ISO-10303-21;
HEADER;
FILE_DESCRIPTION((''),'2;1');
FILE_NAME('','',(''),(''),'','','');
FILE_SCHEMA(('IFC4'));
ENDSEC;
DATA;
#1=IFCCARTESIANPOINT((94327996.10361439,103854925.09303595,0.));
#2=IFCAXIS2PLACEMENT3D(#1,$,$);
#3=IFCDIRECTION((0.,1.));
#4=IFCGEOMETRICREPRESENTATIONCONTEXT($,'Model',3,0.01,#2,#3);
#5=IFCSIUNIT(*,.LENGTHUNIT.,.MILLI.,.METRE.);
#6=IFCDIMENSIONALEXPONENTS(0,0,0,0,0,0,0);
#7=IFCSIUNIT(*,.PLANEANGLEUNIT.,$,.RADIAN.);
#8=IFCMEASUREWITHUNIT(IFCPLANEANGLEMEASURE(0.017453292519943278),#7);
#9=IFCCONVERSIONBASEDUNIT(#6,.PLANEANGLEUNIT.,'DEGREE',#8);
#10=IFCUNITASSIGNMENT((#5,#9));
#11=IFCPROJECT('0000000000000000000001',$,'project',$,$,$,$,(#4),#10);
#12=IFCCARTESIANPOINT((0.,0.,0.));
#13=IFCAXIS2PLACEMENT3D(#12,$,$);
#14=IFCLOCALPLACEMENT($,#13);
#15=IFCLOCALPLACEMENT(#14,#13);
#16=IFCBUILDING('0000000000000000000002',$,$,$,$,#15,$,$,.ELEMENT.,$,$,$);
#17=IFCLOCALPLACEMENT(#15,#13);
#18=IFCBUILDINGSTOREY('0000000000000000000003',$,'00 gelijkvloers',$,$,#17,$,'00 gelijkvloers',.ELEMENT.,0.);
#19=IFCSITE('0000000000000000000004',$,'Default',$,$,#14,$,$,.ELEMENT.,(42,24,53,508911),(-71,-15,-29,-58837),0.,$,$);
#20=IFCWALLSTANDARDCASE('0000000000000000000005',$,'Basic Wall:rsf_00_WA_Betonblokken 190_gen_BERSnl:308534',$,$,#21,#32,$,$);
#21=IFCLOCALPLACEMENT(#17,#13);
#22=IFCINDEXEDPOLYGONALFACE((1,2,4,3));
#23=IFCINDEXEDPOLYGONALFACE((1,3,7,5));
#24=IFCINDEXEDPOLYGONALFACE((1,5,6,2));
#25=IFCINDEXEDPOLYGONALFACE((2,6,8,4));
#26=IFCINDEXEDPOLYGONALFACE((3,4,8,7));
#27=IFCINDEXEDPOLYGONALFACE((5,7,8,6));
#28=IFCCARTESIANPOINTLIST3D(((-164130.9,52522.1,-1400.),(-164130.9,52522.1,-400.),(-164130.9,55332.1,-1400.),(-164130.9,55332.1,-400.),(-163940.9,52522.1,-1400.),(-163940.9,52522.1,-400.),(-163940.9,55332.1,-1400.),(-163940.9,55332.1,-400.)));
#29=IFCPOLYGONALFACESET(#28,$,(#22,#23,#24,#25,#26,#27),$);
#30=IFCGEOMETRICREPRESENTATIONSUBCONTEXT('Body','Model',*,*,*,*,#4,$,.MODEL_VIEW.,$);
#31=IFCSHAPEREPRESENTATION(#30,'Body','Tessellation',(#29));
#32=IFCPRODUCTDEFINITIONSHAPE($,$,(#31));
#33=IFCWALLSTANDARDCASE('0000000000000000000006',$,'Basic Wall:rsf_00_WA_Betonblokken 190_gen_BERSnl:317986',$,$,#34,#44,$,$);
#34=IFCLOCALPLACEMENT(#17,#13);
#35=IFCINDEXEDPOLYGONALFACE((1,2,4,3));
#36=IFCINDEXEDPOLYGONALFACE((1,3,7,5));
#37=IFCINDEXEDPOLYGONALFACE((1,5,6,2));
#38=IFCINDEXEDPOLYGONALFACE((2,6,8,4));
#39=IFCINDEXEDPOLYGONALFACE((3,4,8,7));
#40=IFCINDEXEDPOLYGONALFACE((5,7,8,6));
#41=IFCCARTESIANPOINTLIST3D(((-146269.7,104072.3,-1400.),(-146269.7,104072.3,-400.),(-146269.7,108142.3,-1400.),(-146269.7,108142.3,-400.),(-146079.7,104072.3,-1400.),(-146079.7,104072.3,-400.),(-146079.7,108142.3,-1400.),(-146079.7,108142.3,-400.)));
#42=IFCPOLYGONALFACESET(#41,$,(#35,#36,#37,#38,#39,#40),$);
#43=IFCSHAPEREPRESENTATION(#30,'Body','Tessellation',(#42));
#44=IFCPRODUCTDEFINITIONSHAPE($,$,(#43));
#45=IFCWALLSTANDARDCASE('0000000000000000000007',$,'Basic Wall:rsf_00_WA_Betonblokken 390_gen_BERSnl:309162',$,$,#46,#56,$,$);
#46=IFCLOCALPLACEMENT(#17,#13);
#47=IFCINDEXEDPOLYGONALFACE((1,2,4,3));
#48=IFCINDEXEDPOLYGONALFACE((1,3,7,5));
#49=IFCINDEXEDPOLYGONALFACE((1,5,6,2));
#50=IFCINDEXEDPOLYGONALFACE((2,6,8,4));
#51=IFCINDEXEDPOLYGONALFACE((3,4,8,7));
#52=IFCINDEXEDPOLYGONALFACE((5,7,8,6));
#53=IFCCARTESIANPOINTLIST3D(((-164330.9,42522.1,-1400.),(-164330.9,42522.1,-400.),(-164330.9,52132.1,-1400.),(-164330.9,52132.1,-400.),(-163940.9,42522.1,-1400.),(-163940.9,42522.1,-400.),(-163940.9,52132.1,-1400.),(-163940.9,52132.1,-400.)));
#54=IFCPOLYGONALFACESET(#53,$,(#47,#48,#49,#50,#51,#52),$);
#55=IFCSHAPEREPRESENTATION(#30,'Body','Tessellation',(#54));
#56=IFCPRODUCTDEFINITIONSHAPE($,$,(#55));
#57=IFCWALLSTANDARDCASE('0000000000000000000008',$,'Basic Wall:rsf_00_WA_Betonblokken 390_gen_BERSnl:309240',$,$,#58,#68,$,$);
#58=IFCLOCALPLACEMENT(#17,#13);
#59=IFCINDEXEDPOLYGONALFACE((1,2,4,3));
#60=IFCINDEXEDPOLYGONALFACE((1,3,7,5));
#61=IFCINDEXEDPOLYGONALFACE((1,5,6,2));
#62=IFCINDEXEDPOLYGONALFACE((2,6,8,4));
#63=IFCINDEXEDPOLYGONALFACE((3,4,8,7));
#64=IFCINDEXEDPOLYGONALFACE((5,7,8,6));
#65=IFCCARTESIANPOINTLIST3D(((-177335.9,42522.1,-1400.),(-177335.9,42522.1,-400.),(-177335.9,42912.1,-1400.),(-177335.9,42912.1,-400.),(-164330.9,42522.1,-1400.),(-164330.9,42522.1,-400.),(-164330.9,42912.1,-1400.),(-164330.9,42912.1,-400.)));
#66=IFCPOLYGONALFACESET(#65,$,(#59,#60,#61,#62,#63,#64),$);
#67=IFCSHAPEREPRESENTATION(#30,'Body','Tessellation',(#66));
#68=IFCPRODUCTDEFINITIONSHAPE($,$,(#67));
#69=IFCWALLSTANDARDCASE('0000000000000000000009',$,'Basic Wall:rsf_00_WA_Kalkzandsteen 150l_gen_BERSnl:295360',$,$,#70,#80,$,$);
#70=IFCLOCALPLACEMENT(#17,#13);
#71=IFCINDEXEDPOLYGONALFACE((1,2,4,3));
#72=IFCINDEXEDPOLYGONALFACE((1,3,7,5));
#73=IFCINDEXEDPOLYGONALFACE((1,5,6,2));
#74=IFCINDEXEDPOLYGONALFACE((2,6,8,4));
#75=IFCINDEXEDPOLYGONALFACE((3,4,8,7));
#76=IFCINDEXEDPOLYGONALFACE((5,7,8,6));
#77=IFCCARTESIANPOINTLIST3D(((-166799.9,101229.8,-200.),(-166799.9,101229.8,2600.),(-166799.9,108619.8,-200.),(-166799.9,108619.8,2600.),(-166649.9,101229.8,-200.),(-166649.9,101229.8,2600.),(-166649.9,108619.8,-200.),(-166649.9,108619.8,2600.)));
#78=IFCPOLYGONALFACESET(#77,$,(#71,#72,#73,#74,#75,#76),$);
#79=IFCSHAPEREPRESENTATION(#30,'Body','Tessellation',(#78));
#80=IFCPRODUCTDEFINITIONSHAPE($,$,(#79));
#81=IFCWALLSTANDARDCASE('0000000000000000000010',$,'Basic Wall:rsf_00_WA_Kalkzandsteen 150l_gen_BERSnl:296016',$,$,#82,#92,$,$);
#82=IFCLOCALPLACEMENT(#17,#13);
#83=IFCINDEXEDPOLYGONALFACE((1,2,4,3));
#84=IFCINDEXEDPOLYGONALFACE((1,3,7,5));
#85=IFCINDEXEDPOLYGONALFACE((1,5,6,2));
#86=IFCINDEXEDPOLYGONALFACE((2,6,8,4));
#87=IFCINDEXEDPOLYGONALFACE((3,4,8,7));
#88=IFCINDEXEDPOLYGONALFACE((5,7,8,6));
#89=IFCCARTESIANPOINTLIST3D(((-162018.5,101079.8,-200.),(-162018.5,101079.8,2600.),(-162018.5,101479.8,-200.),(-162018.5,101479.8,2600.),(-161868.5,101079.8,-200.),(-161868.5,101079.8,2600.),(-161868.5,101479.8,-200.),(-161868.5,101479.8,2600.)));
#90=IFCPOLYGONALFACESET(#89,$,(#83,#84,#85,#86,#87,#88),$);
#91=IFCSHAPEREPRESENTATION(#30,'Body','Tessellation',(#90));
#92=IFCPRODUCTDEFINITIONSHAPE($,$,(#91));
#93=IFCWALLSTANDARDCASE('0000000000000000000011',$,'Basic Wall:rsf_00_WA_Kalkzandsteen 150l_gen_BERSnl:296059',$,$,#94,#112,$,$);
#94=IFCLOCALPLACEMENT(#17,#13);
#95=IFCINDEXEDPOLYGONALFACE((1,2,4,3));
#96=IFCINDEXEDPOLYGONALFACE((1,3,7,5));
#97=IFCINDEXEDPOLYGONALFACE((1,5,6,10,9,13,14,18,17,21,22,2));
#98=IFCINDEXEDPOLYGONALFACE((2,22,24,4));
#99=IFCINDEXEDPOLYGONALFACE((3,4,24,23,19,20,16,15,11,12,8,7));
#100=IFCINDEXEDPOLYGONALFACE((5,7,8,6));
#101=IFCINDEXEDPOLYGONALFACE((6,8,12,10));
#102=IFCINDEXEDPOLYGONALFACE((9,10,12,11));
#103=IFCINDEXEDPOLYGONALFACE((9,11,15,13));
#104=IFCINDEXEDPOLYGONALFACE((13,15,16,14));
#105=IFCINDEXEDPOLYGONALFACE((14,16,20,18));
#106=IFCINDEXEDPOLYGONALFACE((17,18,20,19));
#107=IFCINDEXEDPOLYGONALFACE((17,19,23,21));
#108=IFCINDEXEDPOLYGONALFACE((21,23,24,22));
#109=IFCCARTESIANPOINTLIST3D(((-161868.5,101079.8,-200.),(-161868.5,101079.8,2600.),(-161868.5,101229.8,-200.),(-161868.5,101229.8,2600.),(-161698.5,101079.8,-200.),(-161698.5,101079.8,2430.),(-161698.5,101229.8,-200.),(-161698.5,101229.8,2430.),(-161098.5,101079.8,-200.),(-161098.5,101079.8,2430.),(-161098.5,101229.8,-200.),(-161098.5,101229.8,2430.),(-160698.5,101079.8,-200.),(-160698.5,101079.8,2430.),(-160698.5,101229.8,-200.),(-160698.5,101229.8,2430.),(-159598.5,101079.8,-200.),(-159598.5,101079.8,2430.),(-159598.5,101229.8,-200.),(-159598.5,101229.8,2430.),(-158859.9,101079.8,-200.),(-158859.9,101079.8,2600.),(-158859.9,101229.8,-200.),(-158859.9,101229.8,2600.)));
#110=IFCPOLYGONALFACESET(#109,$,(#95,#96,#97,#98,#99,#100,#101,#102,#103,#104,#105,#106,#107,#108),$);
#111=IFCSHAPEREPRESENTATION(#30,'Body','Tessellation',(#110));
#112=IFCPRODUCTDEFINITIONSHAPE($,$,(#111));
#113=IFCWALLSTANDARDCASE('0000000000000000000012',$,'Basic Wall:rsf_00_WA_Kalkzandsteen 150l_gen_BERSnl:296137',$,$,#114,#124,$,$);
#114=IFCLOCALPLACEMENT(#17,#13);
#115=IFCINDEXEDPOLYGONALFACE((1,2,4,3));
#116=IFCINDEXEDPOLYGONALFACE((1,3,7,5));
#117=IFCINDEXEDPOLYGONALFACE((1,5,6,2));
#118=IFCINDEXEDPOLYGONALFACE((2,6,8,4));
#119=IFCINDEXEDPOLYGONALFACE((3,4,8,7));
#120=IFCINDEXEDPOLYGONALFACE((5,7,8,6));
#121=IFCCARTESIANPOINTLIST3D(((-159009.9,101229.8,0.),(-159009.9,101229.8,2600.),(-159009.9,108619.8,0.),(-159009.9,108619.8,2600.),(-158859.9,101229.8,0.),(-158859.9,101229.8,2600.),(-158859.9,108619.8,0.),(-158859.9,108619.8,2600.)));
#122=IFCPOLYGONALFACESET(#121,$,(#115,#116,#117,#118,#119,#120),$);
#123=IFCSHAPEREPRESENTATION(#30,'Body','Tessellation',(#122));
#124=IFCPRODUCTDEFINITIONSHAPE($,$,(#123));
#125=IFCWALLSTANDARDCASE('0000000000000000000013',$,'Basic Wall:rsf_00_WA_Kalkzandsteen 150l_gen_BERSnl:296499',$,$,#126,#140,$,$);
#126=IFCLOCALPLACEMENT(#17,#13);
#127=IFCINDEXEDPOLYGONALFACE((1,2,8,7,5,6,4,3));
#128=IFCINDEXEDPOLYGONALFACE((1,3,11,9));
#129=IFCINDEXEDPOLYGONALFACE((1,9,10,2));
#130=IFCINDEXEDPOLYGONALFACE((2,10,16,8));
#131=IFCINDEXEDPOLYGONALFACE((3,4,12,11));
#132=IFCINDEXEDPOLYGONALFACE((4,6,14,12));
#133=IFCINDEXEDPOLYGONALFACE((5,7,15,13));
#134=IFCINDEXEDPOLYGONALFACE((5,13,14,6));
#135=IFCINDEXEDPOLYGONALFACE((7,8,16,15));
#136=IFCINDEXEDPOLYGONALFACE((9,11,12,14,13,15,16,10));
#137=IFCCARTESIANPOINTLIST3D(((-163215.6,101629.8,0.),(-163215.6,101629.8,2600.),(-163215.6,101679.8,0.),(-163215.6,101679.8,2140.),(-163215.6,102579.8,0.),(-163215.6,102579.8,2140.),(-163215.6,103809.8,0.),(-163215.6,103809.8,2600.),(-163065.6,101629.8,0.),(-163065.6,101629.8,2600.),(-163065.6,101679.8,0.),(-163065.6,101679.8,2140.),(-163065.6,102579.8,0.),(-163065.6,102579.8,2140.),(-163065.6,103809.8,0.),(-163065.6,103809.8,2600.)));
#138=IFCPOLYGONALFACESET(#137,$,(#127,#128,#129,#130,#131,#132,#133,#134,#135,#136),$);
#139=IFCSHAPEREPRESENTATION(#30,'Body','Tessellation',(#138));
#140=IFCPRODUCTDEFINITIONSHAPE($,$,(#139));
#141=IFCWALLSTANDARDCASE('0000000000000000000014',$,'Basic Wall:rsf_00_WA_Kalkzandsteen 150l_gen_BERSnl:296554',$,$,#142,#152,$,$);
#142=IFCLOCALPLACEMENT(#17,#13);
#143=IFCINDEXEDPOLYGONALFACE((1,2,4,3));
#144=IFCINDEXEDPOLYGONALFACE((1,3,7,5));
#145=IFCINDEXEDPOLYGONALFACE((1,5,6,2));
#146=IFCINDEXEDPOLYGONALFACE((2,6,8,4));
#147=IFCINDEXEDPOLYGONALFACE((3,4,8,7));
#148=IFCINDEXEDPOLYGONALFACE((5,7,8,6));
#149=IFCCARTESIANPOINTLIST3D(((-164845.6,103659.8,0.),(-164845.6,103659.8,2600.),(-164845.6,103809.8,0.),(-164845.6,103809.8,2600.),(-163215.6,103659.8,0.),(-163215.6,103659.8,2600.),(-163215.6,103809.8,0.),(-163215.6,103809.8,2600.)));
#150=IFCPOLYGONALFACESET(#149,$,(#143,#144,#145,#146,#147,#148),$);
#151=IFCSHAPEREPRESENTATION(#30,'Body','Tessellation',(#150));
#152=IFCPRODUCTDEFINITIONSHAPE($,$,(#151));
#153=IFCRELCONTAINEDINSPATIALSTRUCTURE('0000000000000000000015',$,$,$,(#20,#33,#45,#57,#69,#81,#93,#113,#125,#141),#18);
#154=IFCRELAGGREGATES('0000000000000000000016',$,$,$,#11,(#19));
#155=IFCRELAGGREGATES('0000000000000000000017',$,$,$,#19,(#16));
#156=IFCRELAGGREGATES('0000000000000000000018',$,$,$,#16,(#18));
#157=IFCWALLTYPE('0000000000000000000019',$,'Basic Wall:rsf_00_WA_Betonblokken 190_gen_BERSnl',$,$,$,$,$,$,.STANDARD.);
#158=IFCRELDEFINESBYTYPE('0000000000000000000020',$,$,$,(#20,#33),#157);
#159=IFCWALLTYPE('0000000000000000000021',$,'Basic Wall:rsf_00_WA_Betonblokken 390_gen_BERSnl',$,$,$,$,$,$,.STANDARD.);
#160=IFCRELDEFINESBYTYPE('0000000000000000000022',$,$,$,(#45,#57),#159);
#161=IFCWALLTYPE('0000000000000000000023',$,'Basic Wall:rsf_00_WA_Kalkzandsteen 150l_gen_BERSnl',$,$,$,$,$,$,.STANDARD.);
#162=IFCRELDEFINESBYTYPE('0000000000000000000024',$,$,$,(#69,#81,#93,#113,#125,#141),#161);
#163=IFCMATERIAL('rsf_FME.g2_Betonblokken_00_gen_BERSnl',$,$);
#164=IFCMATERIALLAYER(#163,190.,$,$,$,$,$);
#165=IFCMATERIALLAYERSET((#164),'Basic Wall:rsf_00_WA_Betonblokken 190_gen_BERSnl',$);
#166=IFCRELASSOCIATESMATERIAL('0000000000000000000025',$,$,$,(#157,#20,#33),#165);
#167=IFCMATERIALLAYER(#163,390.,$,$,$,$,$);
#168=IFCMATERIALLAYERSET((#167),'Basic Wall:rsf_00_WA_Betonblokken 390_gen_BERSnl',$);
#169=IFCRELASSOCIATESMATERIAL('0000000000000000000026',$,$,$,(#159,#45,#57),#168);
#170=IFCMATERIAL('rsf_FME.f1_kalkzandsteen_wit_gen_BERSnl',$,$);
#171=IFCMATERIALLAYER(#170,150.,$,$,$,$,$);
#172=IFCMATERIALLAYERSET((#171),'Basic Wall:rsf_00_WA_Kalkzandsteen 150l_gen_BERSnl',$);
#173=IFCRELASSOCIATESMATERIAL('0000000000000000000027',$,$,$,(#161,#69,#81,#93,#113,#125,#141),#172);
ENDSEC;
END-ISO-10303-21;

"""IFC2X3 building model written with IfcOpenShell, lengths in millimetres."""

from ifc_helpers import new_model, entity, si_unit, converted_unit, direction, frame, frame_2d, origin, origin_2d_with_axis, place, context, subcontext, project, spatial, polyline, rectangle, extrude, clip, bounded_halfspace, material, layer, layer_set, layer_usage, type_object, element, save


model = new_model("IFC2X3")

# Units and contexts
model_context = context("Model", 3, precision=0.01, world=frame((94327996.10361439, 103854925.09303595, 0.0)), true_north=direction((0.0, 1.0)))
body_context = subcontext(model_context, "Body", "Model", "MODEL_VIEW")
ifc_project = project(units=[si_unit("LENGTHUNIT", "METRE", prefix="MILLI"), converted_unit("PLANEANGLEUNIT", "DEGREE", entity("IfcPlaneAngleMeasure", 0.017453292519943278), si_unit("PLANEANGLEUNIT", "RADIAN"), dimensions=[0, 0, 0, 0, 0, 0, 0])], contexts=[model_context])

# Site, building, storey
site_placement = place(None, origin())
site = spatial("IfcSite", under=ifc_project, at=site_placement, Name="Default", CompositionType="ELEMENT", RefLatitude=(42, 24, 53, 508911), RefLongitude=(-71, -15, -29, -58837), RefElevation=0.0)
building_placement = place(site_placement, origin())
building = spatial("IfcBuilding", under=site, at=building_placement, CompositionType="ELEMENT")
storey_placement = place(building_placement, origin())
storey = spatial("IfcBuildingStorey", under=building, at=storey_placement, Name="00 gelijkvloers", LongName="00 gelijkvloers", CompositionType="ELEMENT", Elevation=0.0)

# Walls
ifc_material_1 = material(Name="rsf_FME.g2_Betonblokken_00_gen_BERSnl")
ifc_layer_1 = layer(ifc_material_1, 190.0)
ifc_layer_set_1 = layer_set([ifc_layer_1], Name="Basic Wall:rsf_00_WA_Betonblokken 190_gen_BERSnl")
ifc_layer_usage_1 = layer_usage(ifc_layer_set_1, "AXIS2", "POSITIVE", -95.0)
wall_type_1 = type_object("IfcWallType", Name="Basic Wall:rsf_00_WA_Betonblokken 190_gen_BERSnl", PredefinedType="STANDARD", material=ifc_layer_set_1)
wall_1_placement = place(storey_placement, frame((-164035.9, 55332.1, -1400.0), z_axis=(0.0, 0.0, 1.0), x_axis=(0.0, -1.0, 0.0)))
element("IfcWallStandardCase", 1, at=wall_1_placement, inside=storey, type_object=wall_type_1, material=ifc_layer_usage_1, Name="Basic Wall:rsf_00_WA_Betonblokken 190_gen_BERSnl:308534", context=body_context, shape_type="SweptSolid", body=[
    extrude(rectangle(XDim=2810.0, YDim=190.0, at=frame_2d((1405.0, 0.0), x_axis=(-1.0, 0.0))), origin(), (0.0, 0.0, 1.0), 1000.0),
])
ifc_layer_usage_2 = layer_usage(ifc_layer_set_1, "AXIS2", "POSITIVE", -95.0)
wall_2_placement = place(storey_placement, frame((-146174.7, 104072.3, -1400.0), z_axis=(0.0, 0.0, 1.0), x_axis=(0.0, 1.0, 0.0)))
element("IfcWallStandardCase", 2, at=wall_2_placement, inside=storey, type_object=wall_type_1, material=ifc_layer_usage_2, Name="Basic Wall:rsf_00_WA_Betonblokken 190_gen_BERSnl:317986", context=body_context, shape_type="SweptSolid", body=[
    extrude(rectangle(XDim=4070.0, YDim=190.0, at=frame_2d((2035.0, 0.0), x_axis=(-1.0, 0.0))), origin(), (0.0, 0.0, 1.0), 1000.0),
])
ifc_layer_2 = layer(ifc_material_1, 390.0)
ifc_layer_set_2 = layer_set([ifc_layer_2], Name="Basic Wall:rsf_00_WA_Betonblokken 390_gen_BERSnl")
ifc_layer_usage_3 = layer_usage(ifc_layer_set_2, "AXIS2", "NEGATIVE", 195.0)
wall_type_2 = type_object("IfcWallType", Name="Basic Wall:rsf_00_WA_Betonblokken 390_gen_BERSnl", PredefinedType="STANDARD", material=ifc_layer_set_2)
wall_3_placement = place(storey_placement, frame((-164135.9, 52132.1, -1400.0), z_axis=(0.0, 0.0, 1.0), x_axis=(0.0, -1.0, 0.0)))
element("IfcWallStandardCase", 3, at=wall_3_placement, inside=storey, type_object=wall_type_2, material=ifc_layer_usage_3, Name="Basic Wall:rsf_00_WA_Betonblokken 390_gen_BERSnl:309162", context=body_context, shape_type="SweptSolid", body=[
    extrude(rectangle(XDim=9610.0, YDim=390.0, at=frame_2d((4805.0, 0.0), x_axis=(-1.0, 0.0))), origin(), (0.0, 0.0, 1.0), 1000.0),
])
ifc_layer_usage_4 = layer_usage(ifc_layer_set_2, "AXIS2", "NEGATIVE", 195.0)
wall_4_placement = place(storey_placement, frame((-164330.9, 42717.1, -1400.0), z_axis=(0.0, 0.0, 1.0), x_axis=(-1.0, 0.0, 0.0)))
element("IfcWallStandardCase", 4, at=wall_4_placement, inside=storey, type_object=wall_type_2, material=ifc_layer_usage_4, Name="Basic Wall:rsf_00_WA_Betonblokken 390_gen_BERSnl:309240", context=body_context, shape_type="SweptSolid", body=[
    extrude(rectangle(XDim=13005.0, YDim=390.0, at=frame_2d((6502.5, 0.0), x_axis=(-1.0, 0.0))), origin(), (0.0, 0.0, 1.0), 1000.0),
])
ifc_material_2 = material(Name="rsf_FME.f1_kalkzandsteen_wit_gen_BERSnl")
ifc_layer_3 = layer(ifc_material_2, 150.0)
ifc_layer_set_3 = layer_set([ifc_layer_3], Name="Basic Wall:rsf_00_WA_Kalkzandsteen 150l_gen_BERSnl")
ifc_layer_usage_5 = layer_usage(ifc_layer_set_3, "AXIS2", "NEGATIVE", 75.0)
wall_type_3 = type_object("IfcWallType", Name="Basic Wall:rsf_00_WA_Kalkzandsteen 150l_gen_BERSnl", PredefinedType="STANDARD", material=ifc_layer_set_3)
wall_5_placement = place(storey_placement, frame((-166724.9, 101229.8, -200.0), z_axis=(0.0, 0.0, 1.0), x_axis=(0.0, 1.0, 0.0)))
element("IfcWallStandardCase", 5, at=wall_5_placement, inside=storey, type_object=wall_type_3, material=ifc_layer_usage_5, Name="Basic Wall:rsf_00_WA_Kalkzandsteen 150l_gen_BERSnl:295360", context=body_context, shape_type="Clipping", body=[
    clip(extrude(rectangle(XDim=7390.0, YDim=150.0, at=frame_2d((3695.0, 0.0), x_axis=(-1.0, 0.0))), origin(), (0.0, 0.0, 1.0), 2800.0), bounded_halfspace(frame((0.0, -75.0, 2800.0), z_axis=(0.0, 0.0, -1.0), x_axis=(1.0, 0.0, 0.0)), True, frame((0.0, -75.0, 2800.0)), polyline([(0.0, 0.0), (250.0, 0.0), (7390.0, 0.0), (7390.0, 150.0), (7240.0, 150.0), (0.0, 150.0), (0.0, 0.0)]))),
])
ifc_layer_usage_6 = layer_usage(ifc_layer_set_3, "AXIS2", "NEGATIVE", 75.0)
wall_6_placement = place(storey_placement, frame((-161943.5, 101479.8, -200.0), z_axis=(0.0, 0.0, 1.0), x_axis=(0.0, -1.0, 0.0)))
element("IfcWallStandardCase", 6, at=wall_6_placement, inside=storey, type_object=wall_type_3, material=ifc_layer_usage_6, Name="Basic Wall:rsf_00_WA_Kalkzandsteen 150l_gen_BERSnl:296016", context=body_context, shape_type="Clipping", body=[
    clip(extrude(rectangle(XDim=400.0, YDim=150.0, at=frame_2d((200.0, 0.0), x_axis=(-1.0, 0.0))), origin(), (0.0, 0.0, 1.0), 2800.0), bounded_halfspace(frame((0.0, -75.0, 2800.0), z_axis=(0.0, 0.0, -1.0), x_axis=(-1.0, 0.0, 0.0)), True, frame((0.0, -75.0, 2800.0)), polyline([(0.0, 0.0), (400.0, 0.0), (400.0, 150.0), (250.0, 150.0), (0.0, 150.0), (0.0, 0.0)]))),
])

# Wall, openings
ifc_layer_usage_7 = layer_usage(ifc_layer_set_3, "AXIS2", "NEGATIVE", 75.0)
wall_7_placement = place(storey_placement, frame((-161868.5, 101154.8, -200.0)))
wall_7 = element("IfcWallStandardCase", 7, at=wall_7_placement, inside=storey, type_object=wall_type_3, material=ifc_layer_usage_7, Name="Basic Wall:rsf_00_WA_Kalkzandsteen 150l_gen_BERSnl:296059", context=body_context, shape_type="Clipping", body=[
    clip(extrude(rectangle(XDim=3008.6, YDim=150.0, at=frame_2d((1504.3, 0.0), x_axis=(-1.0, 0.0))), origin(), (0.0, 0.0, 1.0), 2800.0), bounded_halfspace(frame((0.0, -75.0, 2800.0), z_axis=(0.0, 0.0, -1.0), x_axis=(0.0, 1.0, 0.0)), True, frame((0.0, -75.0, 2800.0)), polyline([(0.0, 0.0), (3008.6, 0.0), (3008.6, 150.0), (2858.6, 150.0), (0.0, 150.0), (0.0, 0.0)]))),
])
opening_1_placement = place(wall_7_placement, frame((161868.5, -101154.8, 200.0)))
element("IfcOpeningElement", 8, at=opening_1_placement, cuts=wall_7, ObjectType="Opening", context=body_context, shape_type="SweptSolid", body=[
    extrude(rectangle(XDim=2630.0, YDim=1100.0, at=frame_2d((0.0, 0.0), x_axis=(0.0, 1.0))), frame((-160148.5, 99555.8, 1115.0), z_axis=(0.0, 1.0, 0.0), x_axis=(-1.0, 0.0, 0.0)), (0.0, 0.0, 1.0), 3048.0),
])
opening_2_placement = place(wall_7_placement, frame((161868.5, -101154.8, 200.0)))
element("IfcOpeningElement", 9, at=opening_2_placement, cuts=wall_7, ObjectType="Opening", context=body_context, shape_type="SweptSolid", body=[
    extrude(rectangle(XDim=2630.0, YDim=600.0, at=origin_2d_with_axis()), frame((-161398.5, 99705.8, 1115.0), z_axis=(0.0, 1.0, 0.0), x_axis=(0.0, 0.0, 1.0)), (0.0, 0.0, 1.0), 3048.0),
])

# Wall
ifc_layer_usage_8 = layer_usage(ifc_layer_set_3, "AXIS2", "NEGATIVE", 75.0)
wall_8_placement = place(storey_placement, frame((-158934.9, 101229.8, 0.0), z_axis=(0.0, 0.0, 1.0), x_axis=(0.0, 1.0, 0.0)))
element("IfcWallStandardCase", 10, at=wall_8_placement, inside=storey, type_object=wall_type_3, material=ifc_layer_usage_8, Name="Basic Wall:rsf_00_WA_Kalkzandsteen 150l_gen_BERSnl:296137", context=body_context, shape_type="Clipping", body=[
    clip(extrude(rectangle(XDim=7390.0, YDim=150.0, at=frame_2d((3695.0, 0.0), x_axis=(-1.0, 0.0))), origin(), (0.0, 0.0, 1.0), 2600.0), bounded_halfspace(frame((0.0, -75.0, 2600.0), z_axis=(0.0, 0.0, -1.0), x_axis=(1.0, 0.0, 0.0)), True, frame((0.0, -75.0, 2600.0)), polyline([(0.0, 0.0), (7390.0, 0.0), (7390.0, 150.0), (7240.0, 150.0), (0.0, 150.0), (0.0, 0.0)]))),
])

# Wall, opening
ifc_layer_usage_9 = layer_usage(ifc_layer_set_3, "AXIS2", "POSITIVE", -75.0)
wall_9_placement = place(storey_placement, frame((-163140.6, 101629.8, 0.0), z_axis=(0.0, 0.0, 1.0), x_axis=(0.0, 1.0, 0.0)))
wall_9 = element("IfcWallStandardCase", 11, at=wall_9_placement, inside=storey, type_object=wall_type_3, material=ifc_layer_usage_9, Name="Basic Wall:rsf_00_WA_Kalkzandsteen 150l_gen_BERSnl:296499", context=body_context, shape_type="Clipping", body=[
    clip(extrude(rectangle(XDim=2180.0, YDim=150.0, at=frame_2d((1090.0, 0.0), x_axis=(1.0, 0.0))), origin(), (0.0, 0.0, 1.0), 2600.0), bounded_halfspace(frame((0.0, -75.0, 2600.0), z_axis=(0.0, 0.0, -1.0), x_axis=(1.0, 0.0, 0.0)), True, frame((0.0, -75.0, 2600.0)), polyline([(0.0, 0.0), (2180.0, 0.0), (2180.0, 150.0), (2030.0, 150.0), (0.0, 150.0), (0.0, 0.0)]))),
])
opening_3_placement = place(wall_9_placement, frame((-101629.8, -163140.6, 0.0), z_axis=(0.0, 0.0, 1.0), x_axis=(0.0, -1.0, 0.0)))
element("IfcOpeningElement", 12, at=opening_3_placement, cuts=wall_9, ObjectType="Opening", context=body_context, shape_type="SweptSolid", body=[
    extrude(rectangle(XDim=2340.0, YDim=900.0, at=frame_2d((0.0, 0.0), x_axis=(0.0, 1.0))), frame((-161541.6, 102129.8, 970.0), z_axis=(-1.0, 0.0, 0.0), x_axis=(0.0, -1.0, 0.0)), (0.0, 0.0, 1.0), 3048.0),
])

# Wall
ifc_layer_usage_10 = layer_usage(ifc_layer_set_3, "AXIS2", "POSITIVE", -75.0)
wall_10_placement = place(storey_placement, frame((-163215.6, 103734.8, 0.0), z_axis=(0.0, 0.0, 1.0), x_axis=(-1.0, 0.0, 0.0)))
element("IfcWallStandardCase", 13, at=wall_10_placement, inside=storey, type_object=wall_type_3, material=ifc_layer_usage_10, Name="Basic Wall:rsf_00_WA_Kalkzandsteen 150l_gen_BERSnl:296554", context=body_context, shape_type="Clipping", body=[
    clip(extrude(rectangle(XDim=1630.0, YDim=150.0, at=frame_2d((815.0, 0.0), x_axis=(-1.0, 0.0))), origin(), (0.0, 0.0, 1.0), 2600.0), bounded_halfspace(frame((0.0, -75.0, 2600.0), z_axis=(0.0, 0.0, -1.0), x_axis=(0.0, -1.0, 0.0)), True, frame((0.0, -75.0, 2600.0)), polyline([(0.0, 0.0), (1630.0, 0.0), (1630.0, 150.0), (0.0, 150.0), (0.0, 0.0)]))),
])

save(model, "model.ifc")
